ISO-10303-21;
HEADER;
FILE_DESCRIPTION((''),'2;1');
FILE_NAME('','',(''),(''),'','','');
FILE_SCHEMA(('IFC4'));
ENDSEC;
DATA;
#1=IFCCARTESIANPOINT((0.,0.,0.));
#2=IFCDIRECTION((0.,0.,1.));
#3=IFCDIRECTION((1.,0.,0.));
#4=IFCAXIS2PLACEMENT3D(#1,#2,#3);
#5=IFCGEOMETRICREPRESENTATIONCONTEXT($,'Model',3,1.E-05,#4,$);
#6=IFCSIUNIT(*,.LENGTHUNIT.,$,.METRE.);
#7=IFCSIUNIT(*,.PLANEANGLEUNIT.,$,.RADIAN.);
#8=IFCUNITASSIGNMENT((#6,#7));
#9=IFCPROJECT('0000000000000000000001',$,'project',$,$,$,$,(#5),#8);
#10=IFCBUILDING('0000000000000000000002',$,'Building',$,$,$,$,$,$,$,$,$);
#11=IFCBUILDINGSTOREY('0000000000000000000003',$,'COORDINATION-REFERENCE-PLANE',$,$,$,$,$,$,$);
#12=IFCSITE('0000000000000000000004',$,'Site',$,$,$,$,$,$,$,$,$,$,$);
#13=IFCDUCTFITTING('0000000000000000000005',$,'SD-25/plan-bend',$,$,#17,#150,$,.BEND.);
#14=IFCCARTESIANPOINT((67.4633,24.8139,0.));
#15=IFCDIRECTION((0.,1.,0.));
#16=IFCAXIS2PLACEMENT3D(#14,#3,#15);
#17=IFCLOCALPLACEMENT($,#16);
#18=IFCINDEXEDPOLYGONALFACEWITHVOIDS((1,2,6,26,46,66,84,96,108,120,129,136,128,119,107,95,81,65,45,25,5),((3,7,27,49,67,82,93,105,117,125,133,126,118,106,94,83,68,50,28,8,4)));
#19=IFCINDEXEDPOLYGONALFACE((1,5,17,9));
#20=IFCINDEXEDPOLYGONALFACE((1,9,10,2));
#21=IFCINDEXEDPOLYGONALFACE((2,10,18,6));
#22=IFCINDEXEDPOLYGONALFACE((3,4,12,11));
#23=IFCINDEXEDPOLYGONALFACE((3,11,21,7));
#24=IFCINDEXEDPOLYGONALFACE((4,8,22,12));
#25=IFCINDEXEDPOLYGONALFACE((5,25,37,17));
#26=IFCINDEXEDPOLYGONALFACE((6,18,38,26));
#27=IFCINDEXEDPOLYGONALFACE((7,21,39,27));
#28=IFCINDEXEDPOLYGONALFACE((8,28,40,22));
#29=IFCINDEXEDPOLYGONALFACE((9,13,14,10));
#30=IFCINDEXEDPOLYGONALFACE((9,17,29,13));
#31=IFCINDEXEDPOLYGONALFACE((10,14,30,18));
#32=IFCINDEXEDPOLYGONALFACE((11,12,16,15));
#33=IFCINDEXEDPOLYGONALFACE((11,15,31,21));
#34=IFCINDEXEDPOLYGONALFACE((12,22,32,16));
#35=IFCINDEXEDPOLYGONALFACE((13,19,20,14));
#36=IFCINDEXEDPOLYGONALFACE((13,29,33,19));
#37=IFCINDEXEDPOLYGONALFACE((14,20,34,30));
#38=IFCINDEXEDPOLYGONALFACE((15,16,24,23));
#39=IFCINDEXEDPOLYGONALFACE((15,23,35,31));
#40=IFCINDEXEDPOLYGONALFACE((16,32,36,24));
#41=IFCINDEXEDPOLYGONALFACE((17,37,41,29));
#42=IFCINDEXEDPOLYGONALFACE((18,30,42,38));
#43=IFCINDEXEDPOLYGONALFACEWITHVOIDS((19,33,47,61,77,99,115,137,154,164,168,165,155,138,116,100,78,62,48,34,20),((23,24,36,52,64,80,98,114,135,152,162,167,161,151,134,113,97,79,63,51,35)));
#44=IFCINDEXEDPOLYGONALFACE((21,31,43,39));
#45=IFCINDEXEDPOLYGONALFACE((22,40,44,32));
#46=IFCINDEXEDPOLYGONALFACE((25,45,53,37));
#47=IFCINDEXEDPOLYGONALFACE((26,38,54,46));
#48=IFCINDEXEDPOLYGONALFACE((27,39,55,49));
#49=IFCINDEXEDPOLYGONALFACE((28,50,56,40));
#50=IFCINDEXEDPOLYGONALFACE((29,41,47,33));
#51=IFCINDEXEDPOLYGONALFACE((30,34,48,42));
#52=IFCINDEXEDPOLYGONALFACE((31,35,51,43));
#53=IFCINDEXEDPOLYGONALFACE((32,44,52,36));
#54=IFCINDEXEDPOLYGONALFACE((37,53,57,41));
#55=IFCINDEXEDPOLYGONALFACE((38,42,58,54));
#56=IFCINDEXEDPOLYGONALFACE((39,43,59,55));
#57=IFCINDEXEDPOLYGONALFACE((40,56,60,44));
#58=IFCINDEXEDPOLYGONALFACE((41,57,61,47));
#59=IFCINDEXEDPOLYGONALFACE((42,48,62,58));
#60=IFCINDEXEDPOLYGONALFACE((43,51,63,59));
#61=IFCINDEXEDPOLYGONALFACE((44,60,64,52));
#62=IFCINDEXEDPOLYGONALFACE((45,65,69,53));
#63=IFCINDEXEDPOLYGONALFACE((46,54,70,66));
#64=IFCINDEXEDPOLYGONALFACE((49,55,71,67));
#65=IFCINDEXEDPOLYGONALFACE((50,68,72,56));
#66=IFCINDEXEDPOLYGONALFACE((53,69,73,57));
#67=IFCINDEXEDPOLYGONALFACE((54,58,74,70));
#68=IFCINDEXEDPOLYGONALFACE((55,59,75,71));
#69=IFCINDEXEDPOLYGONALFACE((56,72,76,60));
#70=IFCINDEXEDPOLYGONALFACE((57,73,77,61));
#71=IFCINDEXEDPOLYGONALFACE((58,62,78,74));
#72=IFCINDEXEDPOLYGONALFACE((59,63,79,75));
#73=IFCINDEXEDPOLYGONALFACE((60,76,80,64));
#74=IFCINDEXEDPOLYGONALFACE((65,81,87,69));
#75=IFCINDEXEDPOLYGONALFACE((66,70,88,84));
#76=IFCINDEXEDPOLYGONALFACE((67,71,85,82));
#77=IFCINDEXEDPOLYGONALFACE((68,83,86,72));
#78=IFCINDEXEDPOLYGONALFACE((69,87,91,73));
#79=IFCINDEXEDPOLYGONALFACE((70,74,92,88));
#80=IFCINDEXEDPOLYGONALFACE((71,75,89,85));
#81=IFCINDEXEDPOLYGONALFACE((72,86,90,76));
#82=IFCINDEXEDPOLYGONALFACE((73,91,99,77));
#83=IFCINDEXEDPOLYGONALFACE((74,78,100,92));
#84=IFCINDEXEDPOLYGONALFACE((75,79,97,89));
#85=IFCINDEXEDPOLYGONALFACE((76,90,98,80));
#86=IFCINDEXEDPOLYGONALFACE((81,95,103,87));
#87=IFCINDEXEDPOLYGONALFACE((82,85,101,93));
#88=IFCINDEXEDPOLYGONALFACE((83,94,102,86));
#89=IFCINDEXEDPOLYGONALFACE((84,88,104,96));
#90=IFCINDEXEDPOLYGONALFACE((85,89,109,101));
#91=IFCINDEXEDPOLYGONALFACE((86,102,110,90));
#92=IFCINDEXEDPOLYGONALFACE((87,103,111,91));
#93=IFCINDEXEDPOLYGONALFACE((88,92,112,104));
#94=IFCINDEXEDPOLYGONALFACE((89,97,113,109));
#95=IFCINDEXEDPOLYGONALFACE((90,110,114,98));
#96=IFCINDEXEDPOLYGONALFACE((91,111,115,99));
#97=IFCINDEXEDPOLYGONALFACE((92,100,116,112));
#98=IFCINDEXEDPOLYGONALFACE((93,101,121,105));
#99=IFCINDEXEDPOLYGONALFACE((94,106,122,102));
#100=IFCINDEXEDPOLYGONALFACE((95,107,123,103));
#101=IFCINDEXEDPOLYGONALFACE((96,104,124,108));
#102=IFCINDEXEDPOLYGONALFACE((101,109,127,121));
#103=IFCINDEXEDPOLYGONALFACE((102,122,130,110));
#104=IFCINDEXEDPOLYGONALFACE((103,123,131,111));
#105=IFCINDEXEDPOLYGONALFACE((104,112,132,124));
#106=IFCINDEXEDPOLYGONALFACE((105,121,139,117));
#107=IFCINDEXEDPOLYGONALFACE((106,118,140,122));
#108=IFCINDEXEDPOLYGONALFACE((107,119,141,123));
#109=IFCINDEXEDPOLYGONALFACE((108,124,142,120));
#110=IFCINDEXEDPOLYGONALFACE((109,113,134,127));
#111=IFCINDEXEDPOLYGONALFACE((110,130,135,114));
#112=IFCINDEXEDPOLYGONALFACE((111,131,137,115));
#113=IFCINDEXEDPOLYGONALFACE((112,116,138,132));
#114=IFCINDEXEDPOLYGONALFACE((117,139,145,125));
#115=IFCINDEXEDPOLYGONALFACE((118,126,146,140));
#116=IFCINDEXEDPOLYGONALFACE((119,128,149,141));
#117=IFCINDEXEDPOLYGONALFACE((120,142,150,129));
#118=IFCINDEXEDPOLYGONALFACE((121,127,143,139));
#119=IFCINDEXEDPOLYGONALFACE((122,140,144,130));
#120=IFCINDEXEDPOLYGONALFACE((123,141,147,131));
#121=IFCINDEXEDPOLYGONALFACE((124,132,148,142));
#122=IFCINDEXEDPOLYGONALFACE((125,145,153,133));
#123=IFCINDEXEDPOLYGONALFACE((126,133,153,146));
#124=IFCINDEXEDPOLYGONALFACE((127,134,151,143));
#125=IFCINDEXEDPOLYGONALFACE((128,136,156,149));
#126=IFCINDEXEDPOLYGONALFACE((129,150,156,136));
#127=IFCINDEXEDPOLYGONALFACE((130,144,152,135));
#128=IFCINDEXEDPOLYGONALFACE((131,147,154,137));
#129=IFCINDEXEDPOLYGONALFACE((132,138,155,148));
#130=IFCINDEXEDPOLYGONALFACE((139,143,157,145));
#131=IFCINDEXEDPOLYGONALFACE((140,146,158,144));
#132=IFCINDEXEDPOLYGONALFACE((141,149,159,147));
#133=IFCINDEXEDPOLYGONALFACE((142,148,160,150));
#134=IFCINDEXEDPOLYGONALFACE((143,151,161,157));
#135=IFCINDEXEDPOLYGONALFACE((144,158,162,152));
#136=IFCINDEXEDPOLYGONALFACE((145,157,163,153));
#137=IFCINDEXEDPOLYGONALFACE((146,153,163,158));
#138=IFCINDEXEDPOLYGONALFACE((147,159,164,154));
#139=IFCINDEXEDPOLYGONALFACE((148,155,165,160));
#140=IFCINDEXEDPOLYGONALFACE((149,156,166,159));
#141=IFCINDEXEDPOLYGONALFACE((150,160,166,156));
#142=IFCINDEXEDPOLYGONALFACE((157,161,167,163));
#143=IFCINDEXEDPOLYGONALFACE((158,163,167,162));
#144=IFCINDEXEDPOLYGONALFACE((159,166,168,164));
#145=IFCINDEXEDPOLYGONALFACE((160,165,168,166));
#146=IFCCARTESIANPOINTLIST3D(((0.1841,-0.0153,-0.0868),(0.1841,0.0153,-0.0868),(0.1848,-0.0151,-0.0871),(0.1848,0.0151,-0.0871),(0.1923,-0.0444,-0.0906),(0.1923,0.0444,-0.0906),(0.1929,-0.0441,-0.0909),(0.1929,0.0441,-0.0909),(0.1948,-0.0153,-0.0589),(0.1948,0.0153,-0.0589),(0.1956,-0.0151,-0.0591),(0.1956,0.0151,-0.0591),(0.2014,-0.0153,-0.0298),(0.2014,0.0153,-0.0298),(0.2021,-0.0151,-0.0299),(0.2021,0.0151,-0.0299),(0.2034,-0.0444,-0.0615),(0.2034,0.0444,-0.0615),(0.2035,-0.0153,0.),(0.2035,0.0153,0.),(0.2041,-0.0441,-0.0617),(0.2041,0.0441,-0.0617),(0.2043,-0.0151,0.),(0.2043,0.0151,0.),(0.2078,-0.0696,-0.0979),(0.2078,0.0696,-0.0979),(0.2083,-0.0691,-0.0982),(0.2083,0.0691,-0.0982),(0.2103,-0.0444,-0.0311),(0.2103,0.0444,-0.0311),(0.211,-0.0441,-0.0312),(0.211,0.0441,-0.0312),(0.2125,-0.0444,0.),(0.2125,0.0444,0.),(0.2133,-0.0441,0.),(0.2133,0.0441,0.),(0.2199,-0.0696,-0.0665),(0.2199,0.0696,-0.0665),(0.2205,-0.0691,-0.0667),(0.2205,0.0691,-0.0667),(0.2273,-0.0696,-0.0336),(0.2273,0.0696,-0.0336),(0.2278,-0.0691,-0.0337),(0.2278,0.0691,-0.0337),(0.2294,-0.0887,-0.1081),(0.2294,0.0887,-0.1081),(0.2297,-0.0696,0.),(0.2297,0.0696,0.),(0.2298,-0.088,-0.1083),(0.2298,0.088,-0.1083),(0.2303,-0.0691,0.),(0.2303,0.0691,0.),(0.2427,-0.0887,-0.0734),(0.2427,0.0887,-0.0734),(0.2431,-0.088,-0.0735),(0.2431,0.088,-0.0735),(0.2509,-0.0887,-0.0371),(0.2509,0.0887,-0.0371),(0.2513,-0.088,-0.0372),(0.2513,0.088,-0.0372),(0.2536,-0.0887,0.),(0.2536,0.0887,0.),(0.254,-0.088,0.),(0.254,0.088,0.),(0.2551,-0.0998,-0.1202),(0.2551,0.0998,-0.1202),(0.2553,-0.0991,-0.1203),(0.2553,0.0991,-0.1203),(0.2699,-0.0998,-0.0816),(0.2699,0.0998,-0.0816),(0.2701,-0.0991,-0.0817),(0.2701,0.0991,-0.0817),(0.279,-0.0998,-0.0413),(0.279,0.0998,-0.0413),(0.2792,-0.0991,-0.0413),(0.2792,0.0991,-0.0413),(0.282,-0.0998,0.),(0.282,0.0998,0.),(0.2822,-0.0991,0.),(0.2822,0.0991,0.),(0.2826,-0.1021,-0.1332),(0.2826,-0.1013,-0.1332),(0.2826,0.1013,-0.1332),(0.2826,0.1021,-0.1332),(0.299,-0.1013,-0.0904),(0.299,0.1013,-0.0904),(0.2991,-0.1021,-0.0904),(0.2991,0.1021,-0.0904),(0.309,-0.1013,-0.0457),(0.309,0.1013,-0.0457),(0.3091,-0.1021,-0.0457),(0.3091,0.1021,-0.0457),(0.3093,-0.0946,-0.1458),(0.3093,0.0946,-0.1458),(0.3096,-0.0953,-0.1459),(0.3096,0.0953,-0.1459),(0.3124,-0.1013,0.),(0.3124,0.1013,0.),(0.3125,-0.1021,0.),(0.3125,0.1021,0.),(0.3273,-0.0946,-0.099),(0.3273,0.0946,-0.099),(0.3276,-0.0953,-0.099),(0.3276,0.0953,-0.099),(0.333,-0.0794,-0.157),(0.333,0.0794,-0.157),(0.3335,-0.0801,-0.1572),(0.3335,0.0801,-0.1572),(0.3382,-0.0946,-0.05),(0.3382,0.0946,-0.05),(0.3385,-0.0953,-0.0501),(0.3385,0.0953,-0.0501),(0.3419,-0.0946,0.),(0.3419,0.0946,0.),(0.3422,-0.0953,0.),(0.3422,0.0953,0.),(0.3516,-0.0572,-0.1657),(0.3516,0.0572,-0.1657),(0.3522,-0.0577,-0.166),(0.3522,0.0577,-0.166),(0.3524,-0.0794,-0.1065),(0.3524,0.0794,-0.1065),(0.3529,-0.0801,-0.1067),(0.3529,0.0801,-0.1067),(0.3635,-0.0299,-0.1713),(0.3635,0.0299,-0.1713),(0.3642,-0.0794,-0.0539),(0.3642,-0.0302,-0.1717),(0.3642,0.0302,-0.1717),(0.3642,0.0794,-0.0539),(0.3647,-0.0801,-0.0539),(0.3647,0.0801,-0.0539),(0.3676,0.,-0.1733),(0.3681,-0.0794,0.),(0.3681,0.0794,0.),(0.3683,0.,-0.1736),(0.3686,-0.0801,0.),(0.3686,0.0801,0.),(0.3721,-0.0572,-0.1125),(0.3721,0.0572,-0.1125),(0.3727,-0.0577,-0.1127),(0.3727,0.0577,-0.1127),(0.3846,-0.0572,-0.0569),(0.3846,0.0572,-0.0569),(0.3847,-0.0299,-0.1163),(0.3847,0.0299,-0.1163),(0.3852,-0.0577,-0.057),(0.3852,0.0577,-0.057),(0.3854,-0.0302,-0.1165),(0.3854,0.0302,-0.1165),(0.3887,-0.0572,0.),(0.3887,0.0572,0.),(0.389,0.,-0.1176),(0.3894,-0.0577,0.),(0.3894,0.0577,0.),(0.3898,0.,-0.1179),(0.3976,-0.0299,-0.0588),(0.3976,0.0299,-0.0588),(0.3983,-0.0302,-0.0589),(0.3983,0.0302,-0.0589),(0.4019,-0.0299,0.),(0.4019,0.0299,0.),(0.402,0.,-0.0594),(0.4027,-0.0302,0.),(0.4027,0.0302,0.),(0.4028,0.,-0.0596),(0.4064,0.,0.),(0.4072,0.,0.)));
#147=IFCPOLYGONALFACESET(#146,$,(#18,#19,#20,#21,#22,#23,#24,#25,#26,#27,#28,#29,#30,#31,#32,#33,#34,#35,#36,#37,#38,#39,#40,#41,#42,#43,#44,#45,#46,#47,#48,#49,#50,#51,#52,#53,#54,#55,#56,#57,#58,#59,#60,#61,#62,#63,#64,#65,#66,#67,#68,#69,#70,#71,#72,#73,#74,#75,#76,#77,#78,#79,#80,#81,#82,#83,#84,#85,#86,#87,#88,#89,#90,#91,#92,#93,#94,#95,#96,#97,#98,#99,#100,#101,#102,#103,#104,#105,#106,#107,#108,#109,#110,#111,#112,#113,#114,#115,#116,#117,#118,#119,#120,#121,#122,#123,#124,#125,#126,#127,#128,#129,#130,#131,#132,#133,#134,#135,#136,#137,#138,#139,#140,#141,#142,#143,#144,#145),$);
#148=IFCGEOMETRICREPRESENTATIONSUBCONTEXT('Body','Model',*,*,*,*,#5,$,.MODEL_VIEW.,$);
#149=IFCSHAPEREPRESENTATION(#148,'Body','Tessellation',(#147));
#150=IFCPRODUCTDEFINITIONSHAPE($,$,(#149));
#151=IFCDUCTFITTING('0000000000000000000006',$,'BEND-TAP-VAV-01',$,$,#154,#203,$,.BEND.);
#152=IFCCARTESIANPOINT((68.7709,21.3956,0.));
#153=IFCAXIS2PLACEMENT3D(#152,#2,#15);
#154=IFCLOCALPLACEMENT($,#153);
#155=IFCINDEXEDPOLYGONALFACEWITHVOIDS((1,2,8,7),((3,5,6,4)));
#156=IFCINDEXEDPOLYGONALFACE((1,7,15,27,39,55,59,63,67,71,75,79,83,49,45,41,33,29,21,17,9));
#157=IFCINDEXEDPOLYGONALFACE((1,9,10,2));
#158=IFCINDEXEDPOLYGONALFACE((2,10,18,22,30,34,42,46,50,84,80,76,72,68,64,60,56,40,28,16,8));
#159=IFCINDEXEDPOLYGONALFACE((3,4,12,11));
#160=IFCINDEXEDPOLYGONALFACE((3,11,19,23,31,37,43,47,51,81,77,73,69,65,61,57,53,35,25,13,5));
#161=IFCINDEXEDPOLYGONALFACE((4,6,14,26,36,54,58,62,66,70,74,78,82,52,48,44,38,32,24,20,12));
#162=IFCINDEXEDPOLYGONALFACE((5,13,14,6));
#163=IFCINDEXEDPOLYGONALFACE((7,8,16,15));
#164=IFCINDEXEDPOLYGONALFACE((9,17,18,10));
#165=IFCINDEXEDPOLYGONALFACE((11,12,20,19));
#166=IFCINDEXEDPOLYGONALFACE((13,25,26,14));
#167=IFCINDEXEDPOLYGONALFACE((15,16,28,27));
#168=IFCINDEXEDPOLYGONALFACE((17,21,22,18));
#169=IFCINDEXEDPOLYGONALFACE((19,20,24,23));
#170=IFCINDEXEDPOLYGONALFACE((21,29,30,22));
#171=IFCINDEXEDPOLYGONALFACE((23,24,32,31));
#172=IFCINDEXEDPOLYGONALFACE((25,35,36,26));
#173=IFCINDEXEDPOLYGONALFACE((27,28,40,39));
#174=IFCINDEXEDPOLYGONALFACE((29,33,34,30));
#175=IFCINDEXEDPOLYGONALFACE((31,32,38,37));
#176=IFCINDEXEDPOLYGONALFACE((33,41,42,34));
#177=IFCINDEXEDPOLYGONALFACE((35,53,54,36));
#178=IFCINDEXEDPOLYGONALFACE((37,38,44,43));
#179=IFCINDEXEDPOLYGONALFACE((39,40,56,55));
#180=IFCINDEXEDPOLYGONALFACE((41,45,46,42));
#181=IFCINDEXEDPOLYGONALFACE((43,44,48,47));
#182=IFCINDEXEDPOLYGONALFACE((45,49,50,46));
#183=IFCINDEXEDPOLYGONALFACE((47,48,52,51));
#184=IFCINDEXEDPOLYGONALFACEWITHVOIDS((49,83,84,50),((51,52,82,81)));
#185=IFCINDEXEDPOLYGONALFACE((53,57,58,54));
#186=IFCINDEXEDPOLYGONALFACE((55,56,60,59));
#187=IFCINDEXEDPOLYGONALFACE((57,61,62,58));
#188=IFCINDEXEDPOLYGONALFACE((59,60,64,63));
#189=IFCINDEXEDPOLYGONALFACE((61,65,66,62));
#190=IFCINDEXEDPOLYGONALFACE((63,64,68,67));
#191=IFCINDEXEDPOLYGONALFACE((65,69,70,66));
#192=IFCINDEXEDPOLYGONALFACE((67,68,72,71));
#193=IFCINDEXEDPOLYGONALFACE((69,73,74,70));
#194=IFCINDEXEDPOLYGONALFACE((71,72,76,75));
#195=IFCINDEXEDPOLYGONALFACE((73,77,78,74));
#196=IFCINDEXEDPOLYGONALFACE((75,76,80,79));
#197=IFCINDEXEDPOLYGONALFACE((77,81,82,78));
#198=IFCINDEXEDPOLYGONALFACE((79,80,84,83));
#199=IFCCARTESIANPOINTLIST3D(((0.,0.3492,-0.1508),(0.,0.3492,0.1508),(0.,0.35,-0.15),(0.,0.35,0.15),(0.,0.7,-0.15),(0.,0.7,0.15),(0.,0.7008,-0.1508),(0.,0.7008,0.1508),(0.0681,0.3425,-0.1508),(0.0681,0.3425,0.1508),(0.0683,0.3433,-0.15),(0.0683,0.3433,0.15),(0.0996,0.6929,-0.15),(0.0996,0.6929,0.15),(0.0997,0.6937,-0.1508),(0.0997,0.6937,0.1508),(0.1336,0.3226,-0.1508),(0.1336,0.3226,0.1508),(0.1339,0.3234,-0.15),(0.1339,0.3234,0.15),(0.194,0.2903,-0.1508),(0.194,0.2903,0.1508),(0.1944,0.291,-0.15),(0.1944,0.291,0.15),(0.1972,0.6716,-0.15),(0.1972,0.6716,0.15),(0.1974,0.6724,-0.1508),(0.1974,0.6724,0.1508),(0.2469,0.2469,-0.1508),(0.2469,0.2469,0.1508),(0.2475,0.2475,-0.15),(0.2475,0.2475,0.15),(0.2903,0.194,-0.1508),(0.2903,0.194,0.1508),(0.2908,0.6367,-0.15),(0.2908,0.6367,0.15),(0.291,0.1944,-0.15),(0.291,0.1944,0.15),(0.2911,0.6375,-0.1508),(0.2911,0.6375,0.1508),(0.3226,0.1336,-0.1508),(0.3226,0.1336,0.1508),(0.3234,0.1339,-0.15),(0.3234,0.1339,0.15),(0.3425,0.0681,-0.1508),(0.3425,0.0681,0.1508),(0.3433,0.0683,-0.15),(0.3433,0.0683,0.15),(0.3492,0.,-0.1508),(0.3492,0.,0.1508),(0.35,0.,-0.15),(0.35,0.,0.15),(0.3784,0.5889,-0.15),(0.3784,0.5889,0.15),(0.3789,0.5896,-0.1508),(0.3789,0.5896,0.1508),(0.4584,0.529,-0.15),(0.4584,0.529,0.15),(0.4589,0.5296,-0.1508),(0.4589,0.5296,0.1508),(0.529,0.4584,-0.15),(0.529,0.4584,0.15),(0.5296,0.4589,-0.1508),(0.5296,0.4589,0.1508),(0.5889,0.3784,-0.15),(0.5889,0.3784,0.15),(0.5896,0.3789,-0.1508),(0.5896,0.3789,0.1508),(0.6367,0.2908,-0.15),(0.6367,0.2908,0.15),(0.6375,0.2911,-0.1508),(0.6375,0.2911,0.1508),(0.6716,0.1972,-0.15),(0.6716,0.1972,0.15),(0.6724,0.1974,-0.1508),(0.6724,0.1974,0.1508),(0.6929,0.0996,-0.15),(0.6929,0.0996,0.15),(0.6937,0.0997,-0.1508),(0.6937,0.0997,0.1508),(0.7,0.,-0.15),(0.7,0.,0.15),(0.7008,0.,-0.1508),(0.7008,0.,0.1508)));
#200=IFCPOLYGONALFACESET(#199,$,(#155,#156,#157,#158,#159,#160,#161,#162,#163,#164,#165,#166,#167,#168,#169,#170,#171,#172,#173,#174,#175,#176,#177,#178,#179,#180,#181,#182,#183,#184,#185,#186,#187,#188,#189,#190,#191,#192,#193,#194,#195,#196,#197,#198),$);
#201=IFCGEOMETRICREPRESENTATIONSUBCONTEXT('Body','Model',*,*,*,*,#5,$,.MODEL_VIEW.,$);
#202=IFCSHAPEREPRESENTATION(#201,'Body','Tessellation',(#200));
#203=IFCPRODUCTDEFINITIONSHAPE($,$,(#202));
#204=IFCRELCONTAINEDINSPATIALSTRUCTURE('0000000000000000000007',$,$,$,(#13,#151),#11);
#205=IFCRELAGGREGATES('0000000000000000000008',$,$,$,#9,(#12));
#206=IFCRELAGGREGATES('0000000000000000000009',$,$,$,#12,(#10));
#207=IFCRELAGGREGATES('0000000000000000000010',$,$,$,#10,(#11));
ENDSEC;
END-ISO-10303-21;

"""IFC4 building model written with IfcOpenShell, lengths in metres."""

from ifc_helpers import new_model, entity, si_unit, frame, origin_with_axes, place, context, subcontext, project, spatial, element, save


model = new_model("IFC4")

# Units and contexts
model_context = context("Model", 3, precision=1e-05, world=origin_with_axes())
body_context_1 = subcontext(model_context, "Body", "Model", "MODEL_VIEW")
body_context_2 = subcontext(model_context, "Body", "Model", "MODEL_VIEW")
ifc_project = project(units=[si_unit("LENGTHUNIT", "METRE"), si_unit("PLANEANGLEUNIT", "RADIAN")], contexts=[model_context])

# Site, building, storey
site = spatial("IfcSite", under=ifc_project, Name="Site")
building = spatial("IfcBuilding", under=site, Name="Building")
storey = spatial("IfcBuildingStorey", under=building, Name="COORDINATION-REFERENCE-PLANE")

# Duct fitting
duct_fitting_1_placement = place(None, frame((67.4633, 24.8139, 0.0), z_axis=(1.0, 0.0, 0.0), x_axis=(0.0, 1.0, 0.0)))
element("IfcDuctFitting", 1, at=duct_fitting_1_placement, inside=storey, Name="SD-25/plan-bend", PredefinedType="BEND", context=body_context_1, shape_type="SweptSolid", body=[
    entity("IfcRevolvedAreaSolid", entity("IfcCircleHollowProfileDef", "AREA", None, entity("IfcAxis2Placement2D", entity("IfcCartesianPoint", [0.3048, 0.0])), 0.1024, 0.0008), entity("IfcAxis2Placement3D", entity("IfcCartesianPoint", [0.0, 0.0, 0.0]), entity("IfcDirection", [0.0, 0.0, 1.0]), entity("IfcDirection", [1.0, 0.0, 0.0])), entity("IfcAxis1Placement", entity("IfcCartesianPoint", [0.0, 0.0, 0.0]), entity("IfcDirection", [0.0, 1.0, 0.0])), 0.440428),
])

# Duct fitting
duct_fitting_2_placement = place(None, frame((68.7709, 21.3956, 0.0), z_axis=(0.0, 0.0, 1.0), x_axis=(0.0, 1.0, 0.0)))
cartesian_point = entity("IfcCartesianPoint", [0.0, 0.0, 0.0])
element("IfcDuctFitting", 2, at=duct_fitting_2_placement, inside=storey, Name="BEND-TAP-VAV-01", PredefinedType="BEND", context=body_context_2, shape_type="SweptSolid", body=[
    entity("IfcRevolvedAreaSolid", entity("IfcRectangleHollowProfileDef", "AREA", None, entity("IfcAxis2Placement2D", entity("IfcCartesianPoint", [0.525, 0.0])), 0.3516, 0.3016, 0.0008), entity("IfcAxis2Placement3D", cartesian_point, entity("IfcDirection", [0.0, -1.0, 0.0]), entity("IfcDirection", [1.0, 0.0, 0.0])), entity("IfcAxis1Placement", cartesian_point, entity("IfcDirection", [0.0, 1.0, 0.0])), 1.570796),
])

save(model, "model.ifc")
